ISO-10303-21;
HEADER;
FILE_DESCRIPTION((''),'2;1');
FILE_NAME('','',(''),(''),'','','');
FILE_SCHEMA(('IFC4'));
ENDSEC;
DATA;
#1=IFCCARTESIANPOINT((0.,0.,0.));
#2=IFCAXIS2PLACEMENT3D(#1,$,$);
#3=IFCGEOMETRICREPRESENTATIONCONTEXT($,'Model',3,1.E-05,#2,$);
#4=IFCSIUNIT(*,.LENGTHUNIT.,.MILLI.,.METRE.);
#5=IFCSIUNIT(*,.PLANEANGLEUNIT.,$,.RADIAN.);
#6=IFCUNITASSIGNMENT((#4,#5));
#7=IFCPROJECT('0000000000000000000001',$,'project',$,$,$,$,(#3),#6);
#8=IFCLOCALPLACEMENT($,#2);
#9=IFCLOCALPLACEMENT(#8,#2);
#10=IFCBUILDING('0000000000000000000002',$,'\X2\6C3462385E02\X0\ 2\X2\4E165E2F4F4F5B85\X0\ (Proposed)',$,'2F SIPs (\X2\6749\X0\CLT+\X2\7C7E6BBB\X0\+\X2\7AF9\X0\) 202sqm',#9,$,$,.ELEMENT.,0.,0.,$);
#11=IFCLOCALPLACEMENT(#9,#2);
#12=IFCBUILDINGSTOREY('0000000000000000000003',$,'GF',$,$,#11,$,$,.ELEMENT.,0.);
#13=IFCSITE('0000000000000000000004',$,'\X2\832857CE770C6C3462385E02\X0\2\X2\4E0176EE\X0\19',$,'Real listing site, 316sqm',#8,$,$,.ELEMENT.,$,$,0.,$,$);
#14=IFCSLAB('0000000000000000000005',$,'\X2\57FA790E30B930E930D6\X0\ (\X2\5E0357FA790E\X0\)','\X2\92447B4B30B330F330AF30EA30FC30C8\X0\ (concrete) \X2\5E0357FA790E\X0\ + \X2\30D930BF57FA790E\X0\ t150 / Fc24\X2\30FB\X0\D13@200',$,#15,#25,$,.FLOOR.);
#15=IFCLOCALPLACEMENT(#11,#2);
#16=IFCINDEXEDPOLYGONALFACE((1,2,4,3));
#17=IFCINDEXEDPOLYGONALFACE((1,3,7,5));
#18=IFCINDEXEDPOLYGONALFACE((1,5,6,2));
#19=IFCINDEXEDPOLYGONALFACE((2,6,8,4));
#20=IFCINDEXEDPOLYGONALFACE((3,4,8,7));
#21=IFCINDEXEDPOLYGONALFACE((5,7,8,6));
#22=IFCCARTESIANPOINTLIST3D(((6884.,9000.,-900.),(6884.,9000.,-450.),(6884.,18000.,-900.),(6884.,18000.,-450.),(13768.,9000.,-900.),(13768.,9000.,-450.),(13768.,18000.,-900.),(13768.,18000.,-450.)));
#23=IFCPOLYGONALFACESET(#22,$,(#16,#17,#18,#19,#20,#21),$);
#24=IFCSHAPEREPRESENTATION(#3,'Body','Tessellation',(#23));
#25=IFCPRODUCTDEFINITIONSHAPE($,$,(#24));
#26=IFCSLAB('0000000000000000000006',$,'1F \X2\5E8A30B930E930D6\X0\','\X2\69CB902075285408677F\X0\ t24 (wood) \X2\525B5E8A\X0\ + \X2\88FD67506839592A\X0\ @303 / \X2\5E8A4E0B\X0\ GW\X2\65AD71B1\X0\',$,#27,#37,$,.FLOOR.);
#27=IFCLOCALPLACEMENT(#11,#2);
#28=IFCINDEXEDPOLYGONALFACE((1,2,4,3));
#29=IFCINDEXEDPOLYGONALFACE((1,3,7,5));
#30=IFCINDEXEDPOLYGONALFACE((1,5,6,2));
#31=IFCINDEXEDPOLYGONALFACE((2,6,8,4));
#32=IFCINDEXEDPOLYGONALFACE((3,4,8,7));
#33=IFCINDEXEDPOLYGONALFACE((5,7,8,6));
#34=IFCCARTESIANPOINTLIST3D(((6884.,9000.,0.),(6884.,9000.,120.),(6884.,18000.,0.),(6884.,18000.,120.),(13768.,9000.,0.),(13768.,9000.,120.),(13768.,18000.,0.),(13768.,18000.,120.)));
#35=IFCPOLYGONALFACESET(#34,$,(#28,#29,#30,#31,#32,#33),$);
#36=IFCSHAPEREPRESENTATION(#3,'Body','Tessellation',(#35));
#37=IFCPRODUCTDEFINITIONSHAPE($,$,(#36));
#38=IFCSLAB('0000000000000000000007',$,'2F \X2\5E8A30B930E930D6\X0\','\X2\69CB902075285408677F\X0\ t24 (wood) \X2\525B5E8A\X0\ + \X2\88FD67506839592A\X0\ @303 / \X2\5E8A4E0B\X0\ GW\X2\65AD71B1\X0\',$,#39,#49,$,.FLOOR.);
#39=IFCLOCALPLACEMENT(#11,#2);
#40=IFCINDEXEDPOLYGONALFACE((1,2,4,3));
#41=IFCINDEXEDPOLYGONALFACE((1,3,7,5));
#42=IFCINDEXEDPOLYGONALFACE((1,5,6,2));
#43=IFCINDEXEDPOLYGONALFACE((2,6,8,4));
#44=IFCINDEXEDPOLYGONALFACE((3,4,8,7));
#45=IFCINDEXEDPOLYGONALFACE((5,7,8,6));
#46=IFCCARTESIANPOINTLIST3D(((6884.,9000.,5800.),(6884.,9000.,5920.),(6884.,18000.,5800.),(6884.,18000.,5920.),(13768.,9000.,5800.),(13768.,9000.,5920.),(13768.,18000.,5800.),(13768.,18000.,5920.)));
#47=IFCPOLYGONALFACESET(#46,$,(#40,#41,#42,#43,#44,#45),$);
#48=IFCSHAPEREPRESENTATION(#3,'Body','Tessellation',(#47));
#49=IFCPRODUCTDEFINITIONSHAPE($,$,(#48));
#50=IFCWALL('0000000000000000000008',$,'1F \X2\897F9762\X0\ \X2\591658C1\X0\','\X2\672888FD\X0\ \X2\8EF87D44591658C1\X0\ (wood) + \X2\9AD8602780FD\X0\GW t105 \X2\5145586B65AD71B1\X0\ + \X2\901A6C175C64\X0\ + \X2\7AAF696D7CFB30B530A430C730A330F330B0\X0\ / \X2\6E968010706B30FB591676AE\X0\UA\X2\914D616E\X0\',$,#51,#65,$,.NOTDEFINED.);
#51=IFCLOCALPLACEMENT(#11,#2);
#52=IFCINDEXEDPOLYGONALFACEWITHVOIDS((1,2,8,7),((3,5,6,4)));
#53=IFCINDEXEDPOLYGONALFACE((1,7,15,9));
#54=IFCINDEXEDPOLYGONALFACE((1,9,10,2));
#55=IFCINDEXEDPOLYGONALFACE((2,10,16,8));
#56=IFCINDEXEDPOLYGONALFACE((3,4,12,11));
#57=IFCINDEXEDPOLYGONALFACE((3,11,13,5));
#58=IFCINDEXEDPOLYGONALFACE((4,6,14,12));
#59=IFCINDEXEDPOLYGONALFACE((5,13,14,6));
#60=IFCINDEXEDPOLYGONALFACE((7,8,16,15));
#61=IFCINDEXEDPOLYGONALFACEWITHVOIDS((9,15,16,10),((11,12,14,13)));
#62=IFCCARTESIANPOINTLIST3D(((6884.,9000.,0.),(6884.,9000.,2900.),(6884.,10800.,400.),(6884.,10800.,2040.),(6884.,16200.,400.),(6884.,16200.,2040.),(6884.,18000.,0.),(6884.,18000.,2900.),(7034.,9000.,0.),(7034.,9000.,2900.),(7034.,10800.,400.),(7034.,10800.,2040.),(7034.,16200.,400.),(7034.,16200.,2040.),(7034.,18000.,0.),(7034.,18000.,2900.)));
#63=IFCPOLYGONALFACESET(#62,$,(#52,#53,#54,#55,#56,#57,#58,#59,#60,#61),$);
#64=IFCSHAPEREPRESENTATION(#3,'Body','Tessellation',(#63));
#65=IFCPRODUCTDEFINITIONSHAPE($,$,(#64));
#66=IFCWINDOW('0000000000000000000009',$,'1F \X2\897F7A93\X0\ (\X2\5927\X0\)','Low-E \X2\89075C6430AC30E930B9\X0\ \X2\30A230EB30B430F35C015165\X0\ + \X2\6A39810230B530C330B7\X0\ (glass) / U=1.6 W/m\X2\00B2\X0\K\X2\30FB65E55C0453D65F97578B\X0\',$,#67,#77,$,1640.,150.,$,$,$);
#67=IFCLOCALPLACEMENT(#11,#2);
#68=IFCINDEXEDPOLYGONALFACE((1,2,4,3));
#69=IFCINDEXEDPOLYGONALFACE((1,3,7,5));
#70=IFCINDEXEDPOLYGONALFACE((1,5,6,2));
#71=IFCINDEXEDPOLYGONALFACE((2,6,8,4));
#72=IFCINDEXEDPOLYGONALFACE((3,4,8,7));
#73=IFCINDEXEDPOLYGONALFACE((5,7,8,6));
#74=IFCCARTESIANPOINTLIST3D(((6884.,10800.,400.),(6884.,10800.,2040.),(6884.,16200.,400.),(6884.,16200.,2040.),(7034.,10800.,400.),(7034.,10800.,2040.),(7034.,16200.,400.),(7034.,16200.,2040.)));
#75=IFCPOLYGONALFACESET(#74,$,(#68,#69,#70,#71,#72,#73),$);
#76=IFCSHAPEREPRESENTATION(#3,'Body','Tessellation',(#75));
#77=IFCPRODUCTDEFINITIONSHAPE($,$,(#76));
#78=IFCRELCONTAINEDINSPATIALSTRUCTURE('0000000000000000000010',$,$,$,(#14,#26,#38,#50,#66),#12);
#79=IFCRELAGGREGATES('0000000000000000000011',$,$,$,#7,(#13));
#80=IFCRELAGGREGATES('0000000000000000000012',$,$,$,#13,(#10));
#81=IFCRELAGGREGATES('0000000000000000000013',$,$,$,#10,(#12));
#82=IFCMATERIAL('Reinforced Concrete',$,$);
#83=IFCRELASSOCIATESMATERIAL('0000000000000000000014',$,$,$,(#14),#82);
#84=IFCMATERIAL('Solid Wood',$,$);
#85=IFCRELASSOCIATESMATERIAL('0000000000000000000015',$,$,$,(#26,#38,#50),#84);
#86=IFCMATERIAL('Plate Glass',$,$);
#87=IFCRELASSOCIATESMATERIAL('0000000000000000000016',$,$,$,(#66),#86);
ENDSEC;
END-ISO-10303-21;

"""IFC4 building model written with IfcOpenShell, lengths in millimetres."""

from ifc_helpers import new_model, si_unit, frame, frame_2d, origin, place, context, project, spatial, rectangle, extrude, material, element, fill, save


model = new_model("IFC4")

# Units and contexts
model_context = context("Model", 3, precision=1e-05, world=origin())
ifc_project = project(units=[si_unit("LENGTHUNIT", "METRE", prefix="MILLI"), si_unit("PLANEANGLEUNIT", "RADIAN")], contexts=[model_context])

# Site, building, storey
site_placement = place(None, origin())
site = spatial("IfcSite", under=ifc_project, at=site_placement, Name="茨城県水戸市2丁目19", ObjectType="Real listing site, 316sqm", CompositionType="ELEMENT", RefElevation=0.0)
building_placement = place(site_placement, origin())
building = spatial("IfcBuilding", under=site, at=building_placement, Name="水戸市 2世帯住宅 (Proposed)", ObjectType="2F SIPs (杉CLT+籾殻+竹) 202sqm", CompositionType="ELEMENT", ElevationOfRefHeight=0.0, ElevationOfTerrain=0.0)
storey_placement = place(building_placement, origin())
storey = spatial("IfcBuildingStorey", under=building, at=storey_placement, Name="GF", CompositionType="ELEMENT", Elevation=0.0)

# Slabs
ifc_material_1 = material(Name="Reinforced Concrete")
slab_1_placement = place(storey_placement, frame((3442.0, 4500.0, -450.0)))
element("IfcSlab", 1, at=slab_1_placement, inside=storey, material=ifc_material_1, Name="基礎スラブ (布基礎)", Description="鉄筋コンクリート (concrete) 布基礎 + ベタ基礎 t150 / Fc24・D13@200", PredefinedType="FLOOR", context=model_context, shape_type="SweptSolid", body=[
    extrude(rectangle(XDim=6884.0, YDim=9000.0, at=frame_2d((3442.0, 4500.0))), frame((3442.0, 4500.0, -450.0)), (0.0, 0.0, 1.0), 450.0),
])
ifc_material_2 = material(Name="Solid Wood")
slab_2_placement = place(storey_placement, frame((3442.0, 4500.0, 0.0)))
element("IfcSlab", 2, at=slab_2_placement, inside=storey, material=ifc_material_2, Name="1F 床スラブ", Description="構造用合板 t24 (wood) 剛床 + 製材根太 @303 / 床下 GW断熱", PredefinedType="FLOOR", context=model_context, shape_type="SweptSolid", body=[
    extrude(rectangle(XDim=6884.0, YDim=9000.0, at=frame_2d((3442.0, 4500.0))), frame((3442.0, 4500.0, 0.0)), (0.0, 0.0, 1.0), 120.0),
])
slab_3_placement = place(storey_placement, frame((3442.0, 4500.0, 2900.0)))
element("IfcSlab", 3, at=slab_3_placement, inside=storey, material=ifc_material_2, Name="2F 床スラブ", Description="構造用合板 t24 (wood) 剛床 + 製材根太 @303 / 床下 GW断熱", PredefinedType="FLOOR", context=model_context, shape_type="SweptSolid", body=[
    extrude(rectangle(XDim=6884.0, YDim=9000.0, at=frame_2d((3442.0, 4500.0))), frame((3442.0, 4500.0, 2900.0)), (0.0, 0.0, 1.0), 120.0),
])

# Shared definitions
ifc_material_3 = material(Name="Plate Glass")

# Wall, opening, window
wall_1_placement = place(storey_placement, frame((3442.0, 4500.0, 0.0)))
wall_1 = element("IfcWall", 4, at=wall_1_placement, inside=storey, material=ifc_material_2, Name="1F 西面 外壁", Description="木製 軸組外壁 (wood) + 高性能GW t105 充填断熱 + 通気層 + 窯業系サイディング / 準耐火・外皮UA配慮", PredefinedType="NOTDEFINED", context=model_context, shape_type="SweptSolid", body=[
    extrude(rectangle(XDim=150.0, YDim=9000.0, at=frame_2d((75.0, 4500.0))), frame((3442.0, 4500.0, 0.0)), (0.0, 0.0, 1.0), 2900.0),
])
opening_1_placement = place(storey_placement, frame((3442.0, 5400.0, 200.0)))
opening_1 = element("IfcOpeningElement", 5, at=opening_1_placement, cuts=wall_1, PredefinedType="NOTDEFINED", context=model_context, shape_type="SweptSolid", body=[
    extrude(rectangle(XDim=150.0, YDim=5400.0, at=frame_2d((75.0, 2700.0))), frame((3442.0, 5400.0, 200.0)), (0.0, 0.0, 1.0), 1640.0),
])
window_1_placement = place(storey_placement, frame((3442.0, 5400.0, 200.0)))
window_1 = element("IfcWindow", 6, at=window_1_placement, inside=storey, material=ifc_material_3, Name="1F 西窓 (大)", Description="Low-E 複層ガラス アルゴン封入 + 樹脂サッシ (glass) / U=1.6 W/m²K・日射取得型", OverallHeight=1640.0, OverallWidth=150.0, context=model_context, shape_type="SweptSolid", body=[
    extrude(rectangle(XDim=150.0, YDim=5400.0, at=frame_2d((75.0, 2700.0))), frame((3442.0, 5400.0, 200.0)), (0.0, 0.0, 1.0), 1640.0),
])
fill(opening_1, window_1)

save(model, "model.ifc")
